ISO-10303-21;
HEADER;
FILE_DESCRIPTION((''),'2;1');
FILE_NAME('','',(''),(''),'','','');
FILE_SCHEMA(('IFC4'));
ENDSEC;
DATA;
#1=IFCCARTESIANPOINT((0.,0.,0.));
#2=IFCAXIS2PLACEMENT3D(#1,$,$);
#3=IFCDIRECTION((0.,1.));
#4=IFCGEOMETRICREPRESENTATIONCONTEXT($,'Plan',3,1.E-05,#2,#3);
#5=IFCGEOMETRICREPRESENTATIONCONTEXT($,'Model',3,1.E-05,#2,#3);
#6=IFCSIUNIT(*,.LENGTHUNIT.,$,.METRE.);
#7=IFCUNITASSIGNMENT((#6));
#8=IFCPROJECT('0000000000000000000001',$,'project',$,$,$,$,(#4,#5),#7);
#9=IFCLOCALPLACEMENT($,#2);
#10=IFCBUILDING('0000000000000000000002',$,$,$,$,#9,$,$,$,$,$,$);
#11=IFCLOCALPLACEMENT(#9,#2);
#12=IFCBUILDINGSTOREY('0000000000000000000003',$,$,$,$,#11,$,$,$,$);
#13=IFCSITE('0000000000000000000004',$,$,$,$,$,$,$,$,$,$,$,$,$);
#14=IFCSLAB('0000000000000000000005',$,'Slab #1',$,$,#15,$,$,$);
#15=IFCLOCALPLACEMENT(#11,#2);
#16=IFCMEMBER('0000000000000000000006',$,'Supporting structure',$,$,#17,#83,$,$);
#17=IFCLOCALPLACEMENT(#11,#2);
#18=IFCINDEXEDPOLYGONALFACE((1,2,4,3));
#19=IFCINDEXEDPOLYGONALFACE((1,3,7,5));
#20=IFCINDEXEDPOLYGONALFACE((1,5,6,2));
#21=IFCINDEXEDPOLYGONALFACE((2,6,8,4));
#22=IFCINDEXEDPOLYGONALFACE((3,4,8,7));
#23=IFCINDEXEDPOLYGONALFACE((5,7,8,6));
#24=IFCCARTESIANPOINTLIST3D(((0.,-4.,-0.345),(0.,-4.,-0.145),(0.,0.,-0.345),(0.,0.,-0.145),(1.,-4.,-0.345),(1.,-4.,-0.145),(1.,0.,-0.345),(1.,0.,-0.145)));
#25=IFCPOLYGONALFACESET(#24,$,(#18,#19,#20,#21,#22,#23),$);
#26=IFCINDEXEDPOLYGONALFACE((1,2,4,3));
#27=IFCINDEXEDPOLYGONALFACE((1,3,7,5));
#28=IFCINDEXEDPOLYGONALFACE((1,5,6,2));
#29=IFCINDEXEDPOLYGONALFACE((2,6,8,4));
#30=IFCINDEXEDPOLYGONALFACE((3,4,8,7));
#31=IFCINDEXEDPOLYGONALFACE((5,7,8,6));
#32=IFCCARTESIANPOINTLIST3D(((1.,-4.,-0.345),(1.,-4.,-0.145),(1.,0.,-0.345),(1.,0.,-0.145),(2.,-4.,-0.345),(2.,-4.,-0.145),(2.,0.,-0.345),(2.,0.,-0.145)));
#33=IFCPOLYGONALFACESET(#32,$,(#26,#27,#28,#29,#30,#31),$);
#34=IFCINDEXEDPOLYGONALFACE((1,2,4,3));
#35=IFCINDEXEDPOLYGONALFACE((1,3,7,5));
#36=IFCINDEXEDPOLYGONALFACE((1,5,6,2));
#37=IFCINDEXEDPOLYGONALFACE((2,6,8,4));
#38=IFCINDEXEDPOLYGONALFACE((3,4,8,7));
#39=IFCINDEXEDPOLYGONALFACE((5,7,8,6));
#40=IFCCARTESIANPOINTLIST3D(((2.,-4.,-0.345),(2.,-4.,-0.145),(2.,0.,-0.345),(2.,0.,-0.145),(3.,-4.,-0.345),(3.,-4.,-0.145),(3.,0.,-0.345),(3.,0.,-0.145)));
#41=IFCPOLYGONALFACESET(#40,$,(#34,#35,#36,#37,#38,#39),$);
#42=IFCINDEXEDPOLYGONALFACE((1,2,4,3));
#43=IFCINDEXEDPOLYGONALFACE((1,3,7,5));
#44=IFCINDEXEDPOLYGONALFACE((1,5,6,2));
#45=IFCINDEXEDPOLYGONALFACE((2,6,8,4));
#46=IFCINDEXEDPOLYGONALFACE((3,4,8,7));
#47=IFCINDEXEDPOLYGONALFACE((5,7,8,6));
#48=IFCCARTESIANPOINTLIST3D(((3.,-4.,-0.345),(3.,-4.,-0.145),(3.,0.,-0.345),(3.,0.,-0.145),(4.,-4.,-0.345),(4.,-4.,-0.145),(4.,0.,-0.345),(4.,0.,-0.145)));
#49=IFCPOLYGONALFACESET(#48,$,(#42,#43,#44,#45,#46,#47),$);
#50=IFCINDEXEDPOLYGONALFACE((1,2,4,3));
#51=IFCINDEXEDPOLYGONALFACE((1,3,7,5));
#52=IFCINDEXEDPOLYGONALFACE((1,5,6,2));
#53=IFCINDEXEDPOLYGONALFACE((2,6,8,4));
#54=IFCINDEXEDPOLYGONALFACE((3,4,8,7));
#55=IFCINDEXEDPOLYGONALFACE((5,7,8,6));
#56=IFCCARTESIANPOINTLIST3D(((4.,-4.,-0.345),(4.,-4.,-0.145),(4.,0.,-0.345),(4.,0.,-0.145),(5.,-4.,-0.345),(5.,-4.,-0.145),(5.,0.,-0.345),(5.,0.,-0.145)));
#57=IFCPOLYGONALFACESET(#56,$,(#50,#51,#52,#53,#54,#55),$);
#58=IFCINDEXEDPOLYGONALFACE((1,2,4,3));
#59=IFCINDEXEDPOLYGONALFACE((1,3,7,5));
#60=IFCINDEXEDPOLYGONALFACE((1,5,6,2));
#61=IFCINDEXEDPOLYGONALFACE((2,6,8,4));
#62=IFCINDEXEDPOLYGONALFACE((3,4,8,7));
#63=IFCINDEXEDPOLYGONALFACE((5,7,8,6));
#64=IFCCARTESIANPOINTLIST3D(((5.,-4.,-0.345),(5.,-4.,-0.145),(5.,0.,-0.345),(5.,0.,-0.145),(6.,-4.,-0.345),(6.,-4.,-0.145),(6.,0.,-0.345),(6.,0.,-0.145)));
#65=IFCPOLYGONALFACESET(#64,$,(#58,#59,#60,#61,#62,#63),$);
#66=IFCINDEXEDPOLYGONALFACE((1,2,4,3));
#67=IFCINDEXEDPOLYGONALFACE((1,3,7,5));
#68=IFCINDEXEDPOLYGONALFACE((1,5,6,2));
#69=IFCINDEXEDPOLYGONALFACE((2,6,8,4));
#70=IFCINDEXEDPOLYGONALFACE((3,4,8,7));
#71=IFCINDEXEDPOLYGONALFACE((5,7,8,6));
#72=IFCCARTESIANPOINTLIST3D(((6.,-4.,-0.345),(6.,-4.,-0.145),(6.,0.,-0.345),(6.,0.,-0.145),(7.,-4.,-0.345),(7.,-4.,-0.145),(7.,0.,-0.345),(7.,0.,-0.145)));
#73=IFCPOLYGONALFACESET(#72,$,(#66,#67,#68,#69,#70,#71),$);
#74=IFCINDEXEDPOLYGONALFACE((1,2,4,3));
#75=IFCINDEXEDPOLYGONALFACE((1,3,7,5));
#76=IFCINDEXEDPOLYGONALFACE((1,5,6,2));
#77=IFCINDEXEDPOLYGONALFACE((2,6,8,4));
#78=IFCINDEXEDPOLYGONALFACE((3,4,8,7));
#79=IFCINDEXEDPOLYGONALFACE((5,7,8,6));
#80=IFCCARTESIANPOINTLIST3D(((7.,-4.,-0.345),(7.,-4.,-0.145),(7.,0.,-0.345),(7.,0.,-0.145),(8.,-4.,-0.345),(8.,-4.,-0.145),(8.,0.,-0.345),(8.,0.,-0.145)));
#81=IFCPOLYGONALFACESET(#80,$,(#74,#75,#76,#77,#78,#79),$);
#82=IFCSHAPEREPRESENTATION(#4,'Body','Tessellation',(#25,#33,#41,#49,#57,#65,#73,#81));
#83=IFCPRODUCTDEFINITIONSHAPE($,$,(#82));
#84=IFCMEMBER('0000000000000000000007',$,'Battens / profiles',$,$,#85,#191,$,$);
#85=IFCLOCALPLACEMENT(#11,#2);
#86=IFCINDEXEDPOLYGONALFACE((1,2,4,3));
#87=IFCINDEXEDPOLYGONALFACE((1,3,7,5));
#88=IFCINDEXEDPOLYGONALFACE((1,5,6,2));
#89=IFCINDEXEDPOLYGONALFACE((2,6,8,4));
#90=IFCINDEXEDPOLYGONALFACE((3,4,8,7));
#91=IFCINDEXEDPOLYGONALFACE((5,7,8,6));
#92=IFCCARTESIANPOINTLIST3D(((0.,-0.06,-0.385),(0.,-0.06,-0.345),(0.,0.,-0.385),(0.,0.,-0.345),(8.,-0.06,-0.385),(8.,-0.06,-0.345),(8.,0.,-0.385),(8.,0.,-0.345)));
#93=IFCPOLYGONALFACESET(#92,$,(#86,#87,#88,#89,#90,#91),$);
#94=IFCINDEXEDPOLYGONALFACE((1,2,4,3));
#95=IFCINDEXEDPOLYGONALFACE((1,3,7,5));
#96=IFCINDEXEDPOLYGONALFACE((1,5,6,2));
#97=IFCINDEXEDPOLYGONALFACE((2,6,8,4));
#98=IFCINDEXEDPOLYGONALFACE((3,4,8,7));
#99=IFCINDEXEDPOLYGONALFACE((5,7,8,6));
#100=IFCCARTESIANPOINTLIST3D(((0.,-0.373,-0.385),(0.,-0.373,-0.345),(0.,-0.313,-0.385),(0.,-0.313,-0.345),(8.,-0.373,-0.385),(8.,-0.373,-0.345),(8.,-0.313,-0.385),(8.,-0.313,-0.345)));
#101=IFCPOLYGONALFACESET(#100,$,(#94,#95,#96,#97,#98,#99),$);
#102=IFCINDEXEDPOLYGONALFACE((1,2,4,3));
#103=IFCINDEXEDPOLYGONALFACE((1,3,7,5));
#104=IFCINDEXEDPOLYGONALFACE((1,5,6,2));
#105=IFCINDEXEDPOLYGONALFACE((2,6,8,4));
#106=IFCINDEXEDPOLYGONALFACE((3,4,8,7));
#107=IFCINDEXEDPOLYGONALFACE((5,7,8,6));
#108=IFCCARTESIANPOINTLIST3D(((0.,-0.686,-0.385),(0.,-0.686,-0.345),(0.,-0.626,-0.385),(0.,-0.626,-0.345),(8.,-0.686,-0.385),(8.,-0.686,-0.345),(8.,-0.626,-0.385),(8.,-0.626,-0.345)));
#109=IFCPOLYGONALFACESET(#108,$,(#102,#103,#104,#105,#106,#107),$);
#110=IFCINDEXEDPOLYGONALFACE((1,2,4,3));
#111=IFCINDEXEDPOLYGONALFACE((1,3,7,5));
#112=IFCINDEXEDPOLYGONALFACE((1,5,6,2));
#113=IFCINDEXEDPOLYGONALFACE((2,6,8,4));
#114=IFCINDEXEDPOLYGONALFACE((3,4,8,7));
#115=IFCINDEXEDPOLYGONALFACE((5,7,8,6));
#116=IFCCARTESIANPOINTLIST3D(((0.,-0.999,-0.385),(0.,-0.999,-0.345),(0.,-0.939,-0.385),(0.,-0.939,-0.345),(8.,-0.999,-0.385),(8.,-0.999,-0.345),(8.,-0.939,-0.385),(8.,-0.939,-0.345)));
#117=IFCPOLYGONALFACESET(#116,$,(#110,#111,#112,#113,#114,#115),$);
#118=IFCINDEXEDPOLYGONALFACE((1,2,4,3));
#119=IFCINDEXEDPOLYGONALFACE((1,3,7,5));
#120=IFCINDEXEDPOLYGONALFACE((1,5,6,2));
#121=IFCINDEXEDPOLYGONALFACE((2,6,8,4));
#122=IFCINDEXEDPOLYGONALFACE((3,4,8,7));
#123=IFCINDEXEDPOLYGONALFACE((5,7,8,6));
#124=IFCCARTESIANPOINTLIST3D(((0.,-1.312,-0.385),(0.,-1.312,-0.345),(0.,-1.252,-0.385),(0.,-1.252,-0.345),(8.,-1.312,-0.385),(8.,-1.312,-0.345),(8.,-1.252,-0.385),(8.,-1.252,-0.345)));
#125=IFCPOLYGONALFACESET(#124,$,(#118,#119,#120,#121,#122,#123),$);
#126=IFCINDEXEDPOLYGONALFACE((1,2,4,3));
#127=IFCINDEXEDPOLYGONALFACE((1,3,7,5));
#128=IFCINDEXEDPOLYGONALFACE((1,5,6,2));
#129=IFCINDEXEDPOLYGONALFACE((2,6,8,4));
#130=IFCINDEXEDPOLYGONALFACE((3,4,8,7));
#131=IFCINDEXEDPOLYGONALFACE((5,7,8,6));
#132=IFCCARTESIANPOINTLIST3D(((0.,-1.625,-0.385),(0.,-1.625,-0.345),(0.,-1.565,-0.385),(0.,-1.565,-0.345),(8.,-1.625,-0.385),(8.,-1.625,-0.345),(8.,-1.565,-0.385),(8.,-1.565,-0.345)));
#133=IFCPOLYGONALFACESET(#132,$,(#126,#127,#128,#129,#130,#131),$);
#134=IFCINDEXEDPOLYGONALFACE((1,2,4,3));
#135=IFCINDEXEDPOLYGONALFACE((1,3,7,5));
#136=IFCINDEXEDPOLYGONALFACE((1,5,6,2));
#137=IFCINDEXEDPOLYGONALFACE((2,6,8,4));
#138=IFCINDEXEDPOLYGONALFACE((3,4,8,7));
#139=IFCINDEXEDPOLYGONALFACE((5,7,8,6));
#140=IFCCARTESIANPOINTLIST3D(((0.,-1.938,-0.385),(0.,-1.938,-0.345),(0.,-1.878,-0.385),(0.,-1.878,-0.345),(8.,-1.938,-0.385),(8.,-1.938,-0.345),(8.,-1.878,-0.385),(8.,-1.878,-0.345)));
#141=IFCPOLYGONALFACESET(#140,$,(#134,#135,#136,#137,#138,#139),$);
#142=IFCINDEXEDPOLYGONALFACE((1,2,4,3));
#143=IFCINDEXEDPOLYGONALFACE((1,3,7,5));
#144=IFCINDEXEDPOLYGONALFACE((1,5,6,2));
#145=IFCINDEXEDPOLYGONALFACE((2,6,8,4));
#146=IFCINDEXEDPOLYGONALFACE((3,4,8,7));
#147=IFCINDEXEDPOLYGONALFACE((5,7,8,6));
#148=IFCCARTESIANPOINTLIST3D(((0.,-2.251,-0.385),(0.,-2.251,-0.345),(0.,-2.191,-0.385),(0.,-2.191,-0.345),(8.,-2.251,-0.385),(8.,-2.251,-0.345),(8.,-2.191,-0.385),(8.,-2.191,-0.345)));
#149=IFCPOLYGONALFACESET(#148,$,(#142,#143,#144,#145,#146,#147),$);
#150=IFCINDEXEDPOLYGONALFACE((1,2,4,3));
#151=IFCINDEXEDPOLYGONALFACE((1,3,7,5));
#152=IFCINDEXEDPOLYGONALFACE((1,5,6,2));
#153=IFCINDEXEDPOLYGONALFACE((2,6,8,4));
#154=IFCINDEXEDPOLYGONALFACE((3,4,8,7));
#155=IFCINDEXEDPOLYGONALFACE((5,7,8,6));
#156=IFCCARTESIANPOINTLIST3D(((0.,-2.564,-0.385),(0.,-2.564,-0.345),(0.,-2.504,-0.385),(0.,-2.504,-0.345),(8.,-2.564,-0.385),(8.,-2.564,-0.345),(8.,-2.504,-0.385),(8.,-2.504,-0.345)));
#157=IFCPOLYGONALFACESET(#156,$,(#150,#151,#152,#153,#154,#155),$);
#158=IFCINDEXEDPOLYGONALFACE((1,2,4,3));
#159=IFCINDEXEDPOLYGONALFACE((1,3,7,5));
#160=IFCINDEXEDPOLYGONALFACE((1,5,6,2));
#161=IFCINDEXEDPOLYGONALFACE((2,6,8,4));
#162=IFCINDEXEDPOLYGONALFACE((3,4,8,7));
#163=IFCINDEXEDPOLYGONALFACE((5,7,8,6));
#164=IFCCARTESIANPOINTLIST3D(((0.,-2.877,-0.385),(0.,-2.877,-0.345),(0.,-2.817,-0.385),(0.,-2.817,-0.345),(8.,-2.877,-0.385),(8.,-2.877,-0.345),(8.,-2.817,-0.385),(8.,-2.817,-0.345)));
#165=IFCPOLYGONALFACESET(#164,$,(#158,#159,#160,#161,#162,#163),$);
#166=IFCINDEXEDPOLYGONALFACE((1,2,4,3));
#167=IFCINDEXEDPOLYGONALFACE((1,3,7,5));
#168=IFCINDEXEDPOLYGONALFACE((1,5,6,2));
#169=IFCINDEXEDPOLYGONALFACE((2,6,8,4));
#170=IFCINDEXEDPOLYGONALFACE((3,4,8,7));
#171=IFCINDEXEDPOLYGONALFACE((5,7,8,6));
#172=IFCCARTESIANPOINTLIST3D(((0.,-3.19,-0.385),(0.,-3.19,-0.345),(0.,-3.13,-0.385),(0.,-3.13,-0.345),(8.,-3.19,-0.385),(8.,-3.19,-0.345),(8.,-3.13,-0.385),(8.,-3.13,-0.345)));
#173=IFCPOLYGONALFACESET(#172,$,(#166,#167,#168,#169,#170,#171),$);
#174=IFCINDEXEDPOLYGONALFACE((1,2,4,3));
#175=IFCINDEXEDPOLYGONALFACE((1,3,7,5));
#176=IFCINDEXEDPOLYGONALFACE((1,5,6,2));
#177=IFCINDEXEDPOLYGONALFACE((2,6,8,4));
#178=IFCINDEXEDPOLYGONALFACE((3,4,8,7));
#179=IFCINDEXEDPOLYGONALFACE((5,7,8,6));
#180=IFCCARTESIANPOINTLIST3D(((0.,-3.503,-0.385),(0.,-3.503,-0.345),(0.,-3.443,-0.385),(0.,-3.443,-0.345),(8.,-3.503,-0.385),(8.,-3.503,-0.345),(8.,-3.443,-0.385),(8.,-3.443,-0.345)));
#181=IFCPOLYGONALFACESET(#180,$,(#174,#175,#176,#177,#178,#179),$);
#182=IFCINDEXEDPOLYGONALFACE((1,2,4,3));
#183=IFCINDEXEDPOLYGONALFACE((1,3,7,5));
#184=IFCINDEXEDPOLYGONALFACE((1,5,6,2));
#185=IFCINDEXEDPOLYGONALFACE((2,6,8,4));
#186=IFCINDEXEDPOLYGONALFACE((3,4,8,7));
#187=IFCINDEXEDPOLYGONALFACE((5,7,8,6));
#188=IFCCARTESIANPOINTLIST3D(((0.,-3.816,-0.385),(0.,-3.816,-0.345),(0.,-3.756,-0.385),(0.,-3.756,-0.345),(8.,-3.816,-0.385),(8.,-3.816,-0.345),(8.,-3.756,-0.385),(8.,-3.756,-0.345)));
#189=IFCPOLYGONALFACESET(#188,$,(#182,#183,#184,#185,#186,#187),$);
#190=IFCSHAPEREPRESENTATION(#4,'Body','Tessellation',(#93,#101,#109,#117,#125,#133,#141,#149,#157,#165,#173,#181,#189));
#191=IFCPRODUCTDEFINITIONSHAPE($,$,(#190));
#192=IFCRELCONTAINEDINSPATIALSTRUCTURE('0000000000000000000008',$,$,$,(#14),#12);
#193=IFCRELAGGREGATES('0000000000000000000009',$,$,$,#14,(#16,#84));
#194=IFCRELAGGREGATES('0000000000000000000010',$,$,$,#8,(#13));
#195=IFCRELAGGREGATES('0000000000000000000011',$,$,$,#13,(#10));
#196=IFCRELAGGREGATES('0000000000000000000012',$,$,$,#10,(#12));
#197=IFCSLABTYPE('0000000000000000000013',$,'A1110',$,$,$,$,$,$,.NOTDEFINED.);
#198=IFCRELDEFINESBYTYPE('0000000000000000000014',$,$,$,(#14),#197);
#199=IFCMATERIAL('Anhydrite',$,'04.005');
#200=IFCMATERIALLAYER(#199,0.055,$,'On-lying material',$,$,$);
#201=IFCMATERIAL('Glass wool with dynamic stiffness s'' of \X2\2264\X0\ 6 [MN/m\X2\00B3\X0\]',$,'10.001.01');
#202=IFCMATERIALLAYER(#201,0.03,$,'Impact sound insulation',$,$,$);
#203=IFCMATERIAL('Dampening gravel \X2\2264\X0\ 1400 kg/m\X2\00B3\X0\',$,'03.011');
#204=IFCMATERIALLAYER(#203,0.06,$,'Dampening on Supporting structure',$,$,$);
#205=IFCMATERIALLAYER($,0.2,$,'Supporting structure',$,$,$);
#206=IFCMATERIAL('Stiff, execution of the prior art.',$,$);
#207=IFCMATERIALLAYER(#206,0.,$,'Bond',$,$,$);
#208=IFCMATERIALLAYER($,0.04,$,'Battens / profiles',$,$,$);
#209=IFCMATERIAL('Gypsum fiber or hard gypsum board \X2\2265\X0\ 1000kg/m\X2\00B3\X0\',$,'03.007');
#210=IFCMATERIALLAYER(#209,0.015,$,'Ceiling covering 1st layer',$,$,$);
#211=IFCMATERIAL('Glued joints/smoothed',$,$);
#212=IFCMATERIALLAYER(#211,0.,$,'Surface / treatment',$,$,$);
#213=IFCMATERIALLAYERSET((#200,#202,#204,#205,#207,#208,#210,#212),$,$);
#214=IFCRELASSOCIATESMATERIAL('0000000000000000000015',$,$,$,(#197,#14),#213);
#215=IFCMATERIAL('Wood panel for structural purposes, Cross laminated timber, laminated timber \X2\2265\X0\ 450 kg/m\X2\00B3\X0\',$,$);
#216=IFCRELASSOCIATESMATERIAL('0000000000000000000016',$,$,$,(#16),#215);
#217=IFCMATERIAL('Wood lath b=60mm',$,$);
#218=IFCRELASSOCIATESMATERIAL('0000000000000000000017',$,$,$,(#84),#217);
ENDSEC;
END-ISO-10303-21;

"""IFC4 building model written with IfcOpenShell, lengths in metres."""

from ifc_helpers import new_model, si_unit, direction, frame, frame_2d, origin, place, context, project, spatial, rectangle, extrude, material, layer, layer_set, type_object, element, aggregate, save


model = new_model("IFC4")

# Units and contexts
plan_context = context("Plan", 3, precision=1e-05, world=origin(), true_north=direction((0.0, 1.0)))
model_context = context("Model", 3, precision=1e-05, world=origin(), true_north=direction((0.0, 1.0)))
ifc_project = project(units=[si_unit("LENGTHUNIT", "METRE")], contexts=[plan_context, model_context])

# Site, building, storey
site = spatial("IfcSite", under=ifc_project)
building_placement = place(None, origin())
building = spatial("IfcBuilding", under=site, at=building_placement)
storey_placement = place(building_placement, origin())
storey = spatial("IfcBuildingStorey", under=building, at=storey_placement)

# Slab, members
ifc_material_1 = material(Name="Anhydrite", Category="04.005")
ifc_layer_1 = layer(ifc_material_1, 0.055, Name="On-lying material")
ifc_material_2 = material(Name="Glass wool with dynamic stiffness s' of ≤ 6 [MN/m³]", Category="10.001.01")
ifc_layer_2 = layer(ifc_material_2, 0.03, Name="Impact sound insulation")
ifc_material_3 = material(Name="Dampening gravel ≤ 1400 kg/m³", Category="03.011")
ifc_layer_3 = layer(ifc_material_3, 0.06, Name="Dampening on Supporting structure")
ifc_layer_4 = layer(None, 0.2, Name="Supporting structure")
ifc_material_4 = material(Name="Stiff, execution of the prior art.")
ifc_layer_5 = layer(ifc_material_4, 0.0, Name="Bond")
ifc_layer_6 = layer(None, 0.04, Name="Battens / profiles")
ifc_material_5 = material(Name="Gypsum fiber or hard gypsum board ≥ 1000kg/m³", Category="03.007")
ifc_layer_7 = layer(ifc_material_5, 0.015, Name="Ceiling covering 1st layer")
ifc_material_6 = material(Name="Glued joints/smoothed")
ifc_layer_8 = layer(ifc_material_6, 0.0, Name="Surface / treatment")
ifc_layer_set = layer_set([ifc_layer_1, ifc_layer_2, ifc_layer_3, ifc_layer_4, ifc_layer_5, ifc_layer_6, ifc_layer_7, ifc_layer_8])
slab_type = type_object("IfcSlabType", Name="A1110", PredefinedType="NOTDEFINED", material=ifc_layer_set)
slab_placement = place(None, frame((0.0, 0.0, 0.0), z_axis=(0.0, 0.0, -1.0), x_axis=(1.0, 0.0, 0.0)))
slab = element("IfcSlab", 1, at=slab_placement, inside=storey, type_object=slab_type, material=ifc_layer_set, Name="Slab #1")
ifc_material_7 = material(Name="Wood panel for structural purposes, Cross laminated timber, laminated timber ≥ 450 kg/m³")
member_1_placement = place(slab_placement, origin())
member_1 = element("IfcMember", 2, at=member_1_placement, material=ifc_material_7, Name="Supporting structure", context=plan_context, shape_type="SweptSolid", body=[
    extrude(rectangle(XDim=1.0, YDim=0.2, at=frame_2d((0.5, 0.1), x_axis=(1.0, 0.0))), frame((0.0, 4.0, 0.145), z_axis=(0.0, -1.0, 0.0), x_axis=(1.0, 0.0, 0.0)), (0.0, 0.0, 1.0), 4.0),
    extrude(rectangle(XDim=1.0, YDim=0.2, at=frame_2d((0.5, 0.1), x_axis=(1.0, 0.0))), frame((1.0, 4.0, 0.145), z_axis=(0.0, -1.0, 0.0), x_axis=(1.0, 0.0, 0.0)), (0.0, 0.0, 1.0), 4.0),
    extrude(rectangle(XDim=1.0, YDim=0.2, at=frame_2d((0.5, 0.1), x_axis=(1.0, 0.0))), frame((2.0, 4.0, 0.145), z_axis=(0.0, -1.0, 0.0), x_axis=(1.0, 0.0, 0.0)), (0.0, 0.0, 1.0), 4.0),
    extrude(rectangle(XDim=1.0, YDim=0.2, at=frame_2d((0.5, 0.1), x_axis=(1.0, 0.0))), frame((3.0, 4.0, 0.145), z_axis=(0.0, -1.0, 0.0), x_axis=(1.0, 0.0, 0.0)), (0.0, 0.0, 1.0), 4.0),
    extrude(rectangle(XDim=1.0, YDim=0.2, at=frame_2d((0.5, 0.1), x_axis=(1.0, 0.0))), frame((4.0, 4.0, 0.145), z_axis=(0.0, -1.0, 0.0), x_axis=(1.0, 0.0, 0.0)), (0.0, 0.0, 1.0), 4.0),
    extrude(rectangle(XDim=1.0, YDim=0.2, at=frame_2d((0.5, 0.1), x_axis=(1.0, 0.0))), frame((5.0, 4.0, 0.145), z_axis=(0.0, -1.0, 0.0), x_axis=(1.0, 0.0, 0.0)), (0.0, 0.0, 1.0), 4.0),
    extrude(rectangle(XDim=1.0, YDim=0.2, at=frame_2d((0.5, 0.1), x_axis=(1.0, 0.0))), frame((6.0, 4.0, 0.145), z_axis=(0.0, -1.0, 0.0), x_axis=(1.0, 0.0, 0.0)), (0.0, 0.0, 1.0), 4.0),
    extrude(rectangle(XDim=1.0, YDim=0.2, at=frame_2d((0.5, 0.1), x_axis=(1.0, 0.0))), frame((7.0, 4.0, 0.145), z_axis=(0.0, -1.0, 0.0), x_axis=(1.0, 0.0, 0.0)), (0.0, 0.0, 1.0), 4.0),
])
ifc_material_8 = material(Name="Wood lath b=60mm")
member_2_placement = place(slab_placement, origin())
member_2 = element("IfcMember", 3, at=member_2_placement, material=ifc_material_8, Name="Battens / profiles", context=plan_context, shape_type="SweptSolid", body=[
    extrude(rectangle(XDim=0.06, YDim=0.04, at=frame_2d((0.03, 0.02), x_axis=(1.0, 0.0))), frame((0.0, 0.0, 0.345), z_axis=(1.0, 0.0, 0.0), x_axis=(0.0, 1.0, 0.0)), (0.0, 0.0, 1.0), 8.0),
    extrude(rectangle(XDim=0.06, YDim=0.04, at=frame_2d((0.03, 0.02), x_axis=(1.0, 0.0))), frame((0.0, 0.313, 0.345), z_axis=(1.0, 0.0, 0.0), x_axis=(0.0, 1.0, 0.0)), (0.0, 0.0, 1.0), 8.0),
    extrude(rectangle(XDim=0.06, YDim=0.04, at=frame_2d((0.03, 0.02), x_axis=(1.0, 0.0))), frame((0.0, 0.626, 0.345), z_axis=(1.0, 0.0, 0.0), x_axis=(0.0, 1.0, 0.0)), (0.0, 0.0, 1.0), 8.0),
    extrude(rectangle(XDim=0.06, YDim=0.04, at=frame_2d((0.03, 0.02), x_axis=(1.0, 0.0))), frame((0.0, 0.939, 0.345), z_axis=(1.0, 0.0, 0.0), x_axis=(0.0, 1.0, 0.0)), (0.0, 0.0, 1.0), 8.0),
    extrude(rectangle(XDim=0.06, YDim=0.04, at=frame_2d((0.03, 0.02), x_axis=(1.0, 0.0))), frame((0.0, 1.252, 0.345), z_axis=(1.0, 0.0, 0.0), x_axis=(0.0, 1.0, 0.0)), (0.0, 0.0, 1.0), 8.0),
    extrude(rectangle(XDim=0.06, YDim=0.04, at=frame_2d((0.03, 0.02), x_axis=(1.0, 0.0))), frame((0.0, 1.565, 0.345), z_axis=(1.0, 0.0, 0.0), x_axis=(0.0, 1.0, 0.0)), (0.0, 0.0, 1.0), 8.0),
    extrude(rectangle(XDim=0.06, YDim=0.04, at=frame_2d((0.03, 0.02), x_axis=(1.0, 0.0))), frame((0.0, 1.878, 0.345), z_axis=(1.0, 0.0, 0.0), x_axis=(0.0, 1.0, 0.0)), (0.0, 0.0, 1.0), 8.0),
    extrude(rectangle(XDim=0.06, YDim=0.04, at=frame_2d((0.03, 0.02), x_axis=(1.0, 0.0))), frame((0.0, 2.191, 0.345), z_axis=(1.0, 0.0, 0.0), x_axis=(0.0, 1.0, 0.0)), (0.0, 0.0, 1.0), 8.0),
    extrude(rectangle(XDim=0.06, YDim=0.04, at=frame_2d((0.03, 0.02), x_axis=(1.0, 0.0))), frame((0.0, 2.504, 0.345), z_axis=(1.0, 0.0, 0.0), x_axis=(0.0, 1.0, 0.0)), (0.0, 0.0, 1.0), 8.0),
    extrude(rectangle(XDim=0.06, YDim=0.04, at=frame_2d((0.03, 0.02), x_axis=(1.0, 0.0))), frame((0.0, 2.817, 0.345), z_axis=(1.0, 0.0, 0.0), x_axis=(0.0, 1.0, 0.0)), (0.0, 0.0, 1.0), 8.0),
    extrude(rectangle(XDim=0.06, YDim=0.04, at=frame_2d((0.03, 0.02), x_axis=(1.0, 0.0))), frame((0.0, 3.13, 0.345), z_axis=(1.0, 0.0, 0.0), x_axis=(0.0, 1.0, 0.0)), (0.0, 0.0, 1.0), 8.0),
    extrude(rectangle(XDim=0.06, YDim=0.04, at=frame_2d((0.03, 0.02), x_axis=(1.0, 0.0))), frame((0.0, 3.443, 0.345), z_axis=(1.0, 0.0, 0.0), x_axis=(0.0, 1.0, 0.0)), (0.0, 0.0, 1.0), 8.0),
    extrude(rectangle(XDim=0.06, YDim=0.04, at=frame_2d((0.03, 0.02), x_axis=(1.0, 0.0))), frame((0.0, 3.756, 0.345), z_axis=(1.0, 0.0, 0.0), x_axis=(0.0, 1.0, 0.0)), (0.0, 0.0, 1.0), 8.0),
])
aggregate(slab, [member_1, member_2])

save(model, "model.ifc")
